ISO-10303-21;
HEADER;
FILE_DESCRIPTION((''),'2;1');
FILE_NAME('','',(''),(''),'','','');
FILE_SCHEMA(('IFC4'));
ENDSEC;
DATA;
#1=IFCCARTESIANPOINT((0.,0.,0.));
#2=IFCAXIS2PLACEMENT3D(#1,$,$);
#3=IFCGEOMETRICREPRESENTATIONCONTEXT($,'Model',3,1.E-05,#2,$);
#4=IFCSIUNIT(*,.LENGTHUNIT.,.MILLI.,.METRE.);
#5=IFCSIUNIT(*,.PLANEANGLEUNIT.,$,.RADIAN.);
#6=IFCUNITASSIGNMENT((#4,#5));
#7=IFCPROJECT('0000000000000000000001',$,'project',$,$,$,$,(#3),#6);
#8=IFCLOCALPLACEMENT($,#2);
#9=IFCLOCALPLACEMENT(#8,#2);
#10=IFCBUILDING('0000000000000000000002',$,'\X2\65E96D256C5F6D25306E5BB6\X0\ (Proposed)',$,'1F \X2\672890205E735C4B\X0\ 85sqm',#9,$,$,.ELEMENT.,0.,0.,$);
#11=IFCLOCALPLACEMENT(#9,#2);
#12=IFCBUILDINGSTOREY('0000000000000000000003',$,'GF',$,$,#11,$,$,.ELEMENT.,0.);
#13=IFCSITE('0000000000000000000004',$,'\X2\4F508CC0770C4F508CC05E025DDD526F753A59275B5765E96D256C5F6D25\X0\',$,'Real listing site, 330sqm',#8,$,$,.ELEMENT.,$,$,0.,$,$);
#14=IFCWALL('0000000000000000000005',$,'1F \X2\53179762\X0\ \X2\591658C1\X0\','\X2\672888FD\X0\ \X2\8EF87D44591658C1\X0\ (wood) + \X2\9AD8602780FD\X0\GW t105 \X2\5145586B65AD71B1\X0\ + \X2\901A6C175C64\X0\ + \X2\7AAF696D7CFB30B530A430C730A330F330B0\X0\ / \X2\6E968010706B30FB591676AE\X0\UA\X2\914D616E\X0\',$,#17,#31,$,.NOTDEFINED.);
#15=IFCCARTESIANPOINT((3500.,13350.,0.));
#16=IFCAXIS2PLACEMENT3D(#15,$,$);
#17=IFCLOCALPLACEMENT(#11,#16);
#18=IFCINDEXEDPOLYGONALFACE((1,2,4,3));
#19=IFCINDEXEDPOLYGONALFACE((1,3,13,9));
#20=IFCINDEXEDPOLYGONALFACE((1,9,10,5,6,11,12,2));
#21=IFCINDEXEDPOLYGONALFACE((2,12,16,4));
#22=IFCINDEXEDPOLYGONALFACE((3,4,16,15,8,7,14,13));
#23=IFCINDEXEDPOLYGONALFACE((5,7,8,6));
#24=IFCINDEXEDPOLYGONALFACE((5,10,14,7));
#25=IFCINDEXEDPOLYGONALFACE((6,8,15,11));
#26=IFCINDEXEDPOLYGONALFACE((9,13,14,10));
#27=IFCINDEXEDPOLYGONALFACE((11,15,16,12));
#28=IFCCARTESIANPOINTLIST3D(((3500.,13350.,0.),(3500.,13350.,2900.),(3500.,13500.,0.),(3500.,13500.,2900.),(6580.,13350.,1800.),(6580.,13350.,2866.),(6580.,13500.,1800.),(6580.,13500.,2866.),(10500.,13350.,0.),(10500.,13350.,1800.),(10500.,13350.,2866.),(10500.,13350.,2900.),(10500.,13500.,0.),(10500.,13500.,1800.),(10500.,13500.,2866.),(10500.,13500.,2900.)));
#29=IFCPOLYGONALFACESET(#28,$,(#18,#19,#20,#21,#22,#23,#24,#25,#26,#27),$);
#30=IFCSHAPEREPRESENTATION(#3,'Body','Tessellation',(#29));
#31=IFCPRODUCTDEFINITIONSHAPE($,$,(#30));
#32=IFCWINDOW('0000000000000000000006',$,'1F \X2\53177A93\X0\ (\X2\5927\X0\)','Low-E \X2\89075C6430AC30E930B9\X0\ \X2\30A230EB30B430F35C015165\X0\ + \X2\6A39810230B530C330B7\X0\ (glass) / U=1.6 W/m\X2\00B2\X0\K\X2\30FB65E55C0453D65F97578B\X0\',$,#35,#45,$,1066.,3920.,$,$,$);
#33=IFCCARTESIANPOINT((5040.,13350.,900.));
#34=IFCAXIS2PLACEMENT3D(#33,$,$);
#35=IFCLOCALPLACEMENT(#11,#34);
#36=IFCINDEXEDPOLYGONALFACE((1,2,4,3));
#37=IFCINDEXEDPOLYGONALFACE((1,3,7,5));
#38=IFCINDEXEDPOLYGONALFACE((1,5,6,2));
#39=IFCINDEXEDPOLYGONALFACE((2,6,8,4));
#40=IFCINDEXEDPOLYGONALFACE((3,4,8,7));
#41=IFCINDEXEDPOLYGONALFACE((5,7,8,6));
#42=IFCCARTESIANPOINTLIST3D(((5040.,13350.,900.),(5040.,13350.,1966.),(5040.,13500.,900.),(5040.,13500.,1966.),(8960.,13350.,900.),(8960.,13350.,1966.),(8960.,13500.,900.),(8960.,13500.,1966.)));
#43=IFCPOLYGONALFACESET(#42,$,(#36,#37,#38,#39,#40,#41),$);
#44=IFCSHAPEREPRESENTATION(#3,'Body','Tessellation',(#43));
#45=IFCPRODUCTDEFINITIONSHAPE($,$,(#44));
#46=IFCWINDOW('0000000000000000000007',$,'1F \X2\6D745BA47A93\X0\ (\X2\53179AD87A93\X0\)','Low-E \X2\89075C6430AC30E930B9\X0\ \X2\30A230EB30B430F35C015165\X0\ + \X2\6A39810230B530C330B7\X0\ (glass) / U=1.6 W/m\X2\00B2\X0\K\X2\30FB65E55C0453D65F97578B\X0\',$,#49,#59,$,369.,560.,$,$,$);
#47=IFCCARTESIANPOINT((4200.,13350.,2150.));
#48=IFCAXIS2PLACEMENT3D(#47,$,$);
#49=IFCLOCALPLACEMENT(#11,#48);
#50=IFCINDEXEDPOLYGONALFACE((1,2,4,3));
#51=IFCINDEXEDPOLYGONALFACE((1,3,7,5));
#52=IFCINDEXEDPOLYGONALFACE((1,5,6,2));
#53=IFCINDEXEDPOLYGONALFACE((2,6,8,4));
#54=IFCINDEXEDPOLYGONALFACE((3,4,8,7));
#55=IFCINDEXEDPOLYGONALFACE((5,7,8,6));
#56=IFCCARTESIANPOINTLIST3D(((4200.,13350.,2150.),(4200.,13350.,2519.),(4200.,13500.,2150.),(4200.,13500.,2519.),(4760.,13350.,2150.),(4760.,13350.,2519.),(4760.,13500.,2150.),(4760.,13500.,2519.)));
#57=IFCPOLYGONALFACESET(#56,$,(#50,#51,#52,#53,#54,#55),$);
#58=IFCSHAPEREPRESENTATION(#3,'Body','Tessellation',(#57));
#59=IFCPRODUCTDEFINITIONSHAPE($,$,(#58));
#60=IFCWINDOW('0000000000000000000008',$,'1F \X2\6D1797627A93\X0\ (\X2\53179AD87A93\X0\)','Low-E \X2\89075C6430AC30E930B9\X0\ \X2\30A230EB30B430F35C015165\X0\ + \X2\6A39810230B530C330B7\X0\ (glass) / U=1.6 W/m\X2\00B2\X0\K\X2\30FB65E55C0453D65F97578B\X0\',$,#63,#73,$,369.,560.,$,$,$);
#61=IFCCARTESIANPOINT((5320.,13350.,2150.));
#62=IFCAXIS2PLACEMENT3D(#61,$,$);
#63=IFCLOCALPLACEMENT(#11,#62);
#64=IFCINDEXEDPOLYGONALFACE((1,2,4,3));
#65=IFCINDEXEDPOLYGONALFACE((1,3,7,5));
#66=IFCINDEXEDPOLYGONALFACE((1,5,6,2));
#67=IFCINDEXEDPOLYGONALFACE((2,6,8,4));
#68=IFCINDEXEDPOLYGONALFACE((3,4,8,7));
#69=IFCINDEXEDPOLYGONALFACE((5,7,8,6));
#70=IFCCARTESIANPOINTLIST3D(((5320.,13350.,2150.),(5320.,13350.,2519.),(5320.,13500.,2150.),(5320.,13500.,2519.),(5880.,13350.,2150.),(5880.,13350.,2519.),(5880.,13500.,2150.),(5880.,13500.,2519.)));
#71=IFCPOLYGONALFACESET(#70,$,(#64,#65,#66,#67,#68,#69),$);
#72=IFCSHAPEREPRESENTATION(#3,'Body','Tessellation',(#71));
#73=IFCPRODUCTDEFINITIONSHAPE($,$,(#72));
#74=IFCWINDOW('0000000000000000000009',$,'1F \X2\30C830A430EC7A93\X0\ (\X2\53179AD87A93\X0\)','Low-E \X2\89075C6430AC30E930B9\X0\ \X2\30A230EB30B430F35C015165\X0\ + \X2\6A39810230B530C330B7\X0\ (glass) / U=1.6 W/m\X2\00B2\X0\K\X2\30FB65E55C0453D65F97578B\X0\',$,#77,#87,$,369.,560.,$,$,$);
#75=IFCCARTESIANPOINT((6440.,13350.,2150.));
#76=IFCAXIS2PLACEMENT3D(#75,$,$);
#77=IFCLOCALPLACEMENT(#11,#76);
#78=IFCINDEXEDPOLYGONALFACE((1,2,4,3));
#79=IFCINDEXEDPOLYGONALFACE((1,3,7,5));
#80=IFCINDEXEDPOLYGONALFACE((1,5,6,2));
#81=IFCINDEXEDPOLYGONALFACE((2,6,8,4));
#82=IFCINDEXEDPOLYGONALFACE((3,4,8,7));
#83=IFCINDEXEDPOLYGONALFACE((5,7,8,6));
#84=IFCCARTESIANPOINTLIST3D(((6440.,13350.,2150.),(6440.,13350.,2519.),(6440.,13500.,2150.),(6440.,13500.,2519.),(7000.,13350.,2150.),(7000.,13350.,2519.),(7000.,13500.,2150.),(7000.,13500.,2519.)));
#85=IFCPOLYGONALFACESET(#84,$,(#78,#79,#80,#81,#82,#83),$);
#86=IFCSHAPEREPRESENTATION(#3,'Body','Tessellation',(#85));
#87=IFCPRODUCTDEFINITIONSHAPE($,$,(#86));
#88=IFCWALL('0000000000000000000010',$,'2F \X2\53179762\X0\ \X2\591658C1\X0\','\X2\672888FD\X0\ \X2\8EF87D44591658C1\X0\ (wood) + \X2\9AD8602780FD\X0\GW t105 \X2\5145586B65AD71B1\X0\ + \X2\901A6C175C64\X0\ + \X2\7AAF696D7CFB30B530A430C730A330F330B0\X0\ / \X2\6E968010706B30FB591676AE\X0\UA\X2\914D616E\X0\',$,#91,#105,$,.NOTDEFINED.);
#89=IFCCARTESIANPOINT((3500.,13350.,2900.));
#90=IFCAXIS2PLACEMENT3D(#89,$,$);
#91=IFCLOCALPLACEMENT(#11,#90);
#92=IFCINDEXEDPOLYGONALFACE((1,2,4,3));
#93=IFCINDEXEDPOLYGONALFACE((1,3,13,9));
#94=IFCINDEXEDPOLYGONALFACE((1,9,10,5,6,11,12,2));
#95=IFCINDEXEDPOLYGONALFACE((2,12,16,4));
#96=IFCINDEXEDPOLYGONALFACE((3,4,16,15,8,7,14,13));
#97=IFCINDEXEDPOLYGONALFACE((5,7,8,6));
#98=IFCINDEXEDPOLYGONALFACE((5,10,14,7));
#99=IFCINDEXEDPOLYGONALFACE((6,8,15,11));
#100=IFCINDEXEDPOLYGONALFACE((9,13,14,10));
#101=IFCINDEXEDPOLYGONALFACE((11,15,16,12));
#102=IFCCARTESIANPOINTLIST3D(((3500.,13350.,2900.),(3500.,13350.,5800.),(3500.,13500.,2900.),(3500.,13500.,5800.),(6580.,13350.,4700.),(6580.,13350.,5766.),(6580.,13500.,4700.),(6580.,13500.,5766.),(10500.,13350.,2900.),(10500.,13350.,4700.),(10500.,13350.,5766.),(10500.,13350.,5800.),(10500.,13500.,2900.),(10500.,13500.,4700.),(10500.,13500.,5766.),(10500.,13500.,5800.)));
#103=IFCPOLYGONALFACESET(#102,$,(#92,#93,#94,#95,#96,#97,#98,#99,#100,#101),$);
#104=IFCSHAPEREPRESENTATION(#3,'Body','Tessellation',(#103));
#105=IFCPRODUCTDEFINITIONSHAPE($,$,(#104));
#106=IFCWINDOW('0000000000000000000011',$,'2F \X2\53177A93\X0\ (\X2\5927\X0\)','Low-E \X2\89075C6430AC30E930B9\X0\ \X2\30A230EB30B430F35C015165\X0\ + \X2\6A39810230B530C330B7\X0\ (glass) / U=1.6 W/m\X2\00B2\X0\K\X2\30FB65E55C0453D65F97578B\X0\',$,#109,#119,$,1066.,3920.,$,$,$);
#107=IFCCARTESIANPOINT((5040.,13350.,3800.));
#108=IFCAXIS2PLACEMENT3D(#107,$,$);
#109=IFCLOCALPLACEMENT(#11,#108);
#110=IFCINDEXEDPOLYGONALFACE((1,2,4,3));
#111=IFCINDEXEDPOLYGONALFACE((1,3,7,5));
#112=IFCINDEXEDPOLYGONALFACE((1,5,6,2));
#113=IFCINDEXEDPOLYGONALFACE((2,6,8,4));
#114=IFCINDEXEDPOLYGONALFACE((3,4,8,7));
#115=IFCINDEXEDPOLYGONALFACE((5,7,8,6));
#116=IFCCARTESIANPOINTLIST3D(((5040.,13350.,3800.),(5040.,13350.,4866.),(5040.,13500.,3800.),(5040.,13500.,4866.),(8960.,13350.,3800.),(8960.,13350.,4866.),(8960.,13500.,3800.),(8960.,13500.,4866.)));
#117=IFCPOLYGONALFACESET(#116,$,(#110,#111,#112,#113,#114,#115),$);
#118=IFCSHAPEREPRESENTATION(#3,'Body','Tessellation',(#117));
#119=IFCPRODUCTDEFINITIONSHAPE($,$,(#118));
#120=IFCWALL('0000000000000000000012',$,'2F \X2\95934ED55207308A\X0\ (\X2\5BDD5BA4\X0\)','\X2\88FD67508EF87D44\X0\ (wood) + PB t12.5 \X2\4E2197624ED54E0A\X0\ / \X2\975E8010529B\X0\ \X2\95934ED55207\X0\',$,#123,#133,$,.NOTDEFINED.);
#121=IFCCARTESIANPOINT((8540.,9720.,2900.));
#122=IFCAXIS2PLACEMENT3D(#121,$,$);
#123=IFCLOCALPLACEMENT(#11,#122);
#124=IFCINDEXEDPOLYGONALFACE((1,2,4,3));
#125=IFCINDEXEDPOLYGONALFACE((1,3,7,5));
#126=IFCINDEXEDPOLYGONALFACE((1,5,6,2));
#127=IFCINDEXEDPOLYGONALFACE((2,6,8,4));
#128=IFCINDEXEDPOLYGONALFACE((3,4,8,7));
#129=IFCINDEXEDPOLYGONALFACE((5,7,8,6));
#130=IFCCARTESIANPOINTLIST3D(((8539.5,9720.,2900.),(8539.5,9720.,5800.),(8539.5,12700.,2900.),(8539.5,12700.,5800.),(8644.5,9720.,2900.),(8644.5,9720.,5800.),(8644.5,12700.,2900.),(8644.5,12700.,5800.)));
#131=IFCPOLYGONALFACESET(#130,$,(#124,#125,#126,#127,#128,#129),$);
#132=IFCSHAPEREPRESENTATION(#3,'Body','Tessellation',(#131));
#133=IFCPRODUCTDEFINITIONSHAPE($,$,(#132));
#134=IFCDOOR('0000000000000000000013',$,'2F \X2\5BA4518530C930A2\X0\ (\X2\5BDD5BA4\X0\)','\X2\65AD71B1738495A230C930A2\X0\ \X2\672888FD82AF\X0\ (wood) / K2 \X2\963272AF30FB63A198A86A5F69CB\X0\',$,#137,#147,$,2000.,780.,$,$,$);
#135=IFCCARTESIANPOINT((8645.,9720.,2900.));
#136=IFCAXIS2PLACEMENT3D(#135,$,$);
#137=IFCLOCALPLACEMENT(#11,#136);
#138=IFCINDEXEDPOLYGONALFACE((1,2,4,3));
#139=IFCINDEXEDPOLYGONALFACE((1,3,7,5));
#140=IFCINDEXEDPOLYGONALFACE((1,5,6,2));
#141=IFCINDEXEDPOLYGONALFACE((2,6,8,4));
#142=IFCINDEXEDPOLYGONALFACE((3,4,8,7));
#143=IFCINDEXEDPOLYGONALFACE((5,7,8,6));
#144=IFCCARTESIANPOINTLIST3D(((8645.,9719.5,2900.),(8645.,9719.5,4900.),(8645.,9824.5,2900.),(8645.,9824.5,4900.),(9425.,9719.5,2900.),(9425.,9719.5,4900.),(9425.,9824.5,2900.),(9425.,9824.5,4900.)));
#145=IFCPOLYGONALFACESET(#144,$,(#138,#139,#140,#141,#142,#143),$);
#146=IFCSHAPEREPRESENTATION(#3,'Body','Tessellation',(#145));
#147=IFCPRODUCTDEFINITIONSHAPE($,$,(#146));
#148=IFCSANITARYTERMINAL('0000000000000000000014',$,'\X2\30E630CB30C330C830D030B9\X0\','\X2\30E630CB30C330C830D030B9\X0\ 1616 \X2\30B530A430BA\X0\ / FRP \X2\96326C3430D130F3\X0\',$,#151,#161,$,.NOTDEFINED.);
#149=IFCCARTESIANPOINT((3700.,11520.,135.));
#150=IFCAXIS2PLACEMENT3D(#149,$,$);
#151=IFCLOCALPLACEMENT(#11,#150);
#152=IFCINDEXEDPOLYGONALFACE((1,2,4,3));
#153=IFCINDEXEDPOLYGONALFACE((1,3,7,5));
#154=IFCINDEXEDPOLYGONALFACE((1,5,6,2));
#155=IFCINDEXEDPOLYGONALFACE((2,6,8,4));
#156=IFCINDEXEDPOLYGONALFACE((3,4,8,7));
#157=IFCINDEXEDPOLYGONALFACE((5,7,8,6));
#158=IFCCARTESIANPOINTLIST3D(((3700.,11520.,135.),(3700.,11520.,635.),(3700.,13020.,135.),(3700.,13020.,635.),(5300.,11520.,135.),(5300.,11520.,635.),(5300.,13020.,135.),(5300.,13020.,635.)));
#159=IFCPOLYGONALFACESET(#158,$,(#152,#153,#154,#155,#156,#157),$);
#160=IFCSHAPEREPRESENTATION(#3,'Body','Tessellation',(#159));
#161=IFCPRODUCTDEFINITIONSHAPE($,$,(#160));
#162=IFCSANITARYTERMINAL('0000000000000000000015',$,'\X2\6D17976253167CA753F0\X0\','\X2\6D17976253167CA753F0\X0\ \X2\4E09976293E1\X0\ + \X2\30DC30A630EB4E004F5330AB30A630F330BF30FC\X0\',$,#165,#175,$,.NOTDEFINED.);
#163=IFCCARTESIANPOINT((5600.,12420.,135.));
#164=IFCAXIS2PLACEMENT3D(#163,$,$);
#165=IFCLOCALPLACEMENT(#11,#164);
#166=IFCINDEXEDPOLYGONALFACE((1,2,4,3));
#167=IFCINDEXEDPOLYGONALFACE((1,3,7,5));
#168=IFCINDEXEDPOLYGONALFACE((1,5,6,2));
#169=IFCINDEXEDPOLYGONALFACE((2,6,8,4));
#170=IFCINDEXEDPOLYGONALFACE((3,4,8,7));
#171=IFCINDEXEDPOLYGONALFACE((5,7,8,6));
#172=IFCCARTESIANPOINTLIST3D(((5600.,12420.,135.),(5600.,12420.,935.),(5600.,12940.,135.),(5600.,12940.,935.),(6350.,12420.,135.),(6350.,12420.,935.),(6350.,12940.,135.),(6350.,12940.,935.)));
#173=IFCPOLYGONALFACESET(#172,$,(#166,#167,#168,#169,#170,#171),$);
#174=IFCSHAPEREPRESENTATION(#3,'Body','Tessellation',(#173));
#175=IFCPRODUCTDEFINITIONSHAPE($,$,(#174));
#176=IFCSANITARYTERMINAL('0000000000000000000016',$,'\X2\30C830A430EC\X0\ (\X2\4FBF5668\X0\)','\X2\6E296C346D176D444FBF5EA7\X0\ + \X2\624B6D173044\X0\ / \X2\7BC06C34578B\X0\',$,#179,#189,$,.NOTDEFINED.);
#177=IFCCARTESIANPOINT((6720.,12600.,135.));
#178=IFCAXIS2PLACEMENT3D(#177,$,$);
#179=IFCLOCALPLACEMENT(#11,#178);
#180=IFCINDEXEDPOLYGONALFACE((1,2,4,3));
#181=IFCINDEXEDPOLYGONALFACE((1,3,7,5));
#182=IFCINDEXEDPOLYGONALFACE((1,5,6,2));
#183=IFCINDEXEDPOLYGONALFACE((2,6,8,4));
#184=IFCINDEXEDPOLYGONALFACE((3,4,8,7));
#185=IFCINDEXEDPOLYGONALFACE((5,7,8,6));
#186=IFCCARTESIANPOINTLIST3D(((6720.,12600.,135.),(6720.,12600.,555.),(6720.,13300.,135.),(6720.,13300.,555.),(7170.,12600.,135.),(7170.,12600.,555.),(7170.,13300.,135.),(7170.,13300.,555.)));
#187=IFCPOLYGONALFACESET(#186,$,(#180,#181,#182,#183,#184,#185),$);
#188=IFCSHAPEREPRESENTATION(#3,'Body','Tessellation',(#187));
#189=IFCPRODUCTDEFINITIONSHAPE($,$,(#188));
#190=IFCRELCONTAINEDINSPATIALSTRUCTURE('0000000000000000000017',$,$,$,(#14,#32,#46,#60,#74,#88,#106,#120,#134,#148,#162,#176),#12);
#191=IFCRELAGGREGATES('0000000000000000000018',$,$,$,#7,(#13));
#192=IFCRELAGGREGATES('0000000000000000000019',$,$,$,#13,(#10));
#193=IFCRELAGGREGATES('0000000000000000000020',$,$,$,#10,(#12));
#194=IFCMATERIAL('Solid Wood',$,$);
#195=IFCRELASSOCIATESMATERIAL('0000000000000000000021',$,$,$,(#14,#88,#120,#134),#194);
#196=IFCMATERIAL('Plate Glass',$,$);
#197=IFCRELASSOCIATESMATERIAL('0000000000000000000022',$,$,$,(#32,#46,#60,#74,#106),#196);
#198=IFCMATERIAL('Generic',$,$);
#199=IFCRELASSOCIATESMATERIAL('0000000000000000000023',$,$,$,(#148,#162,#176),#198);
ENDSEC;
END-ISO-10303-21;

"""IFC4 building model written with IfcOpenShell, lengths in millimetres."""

from ifc_helpers import new_model, si_unit, frame, frame_2d, origin, place, context, project, spatial, rectangle, extrude, material, element, fill, save


model = new_model("IFC4")

# Units and contexts
model_context = context("Model", 3, precision=1e-05, world=origin())
ifc_project = project(units=[si_unit("LENGTHUNIT", "METRE", prefix="MILLI"), si_unit("PLANEANGLEUNIT", "RADIAN")], contexts=[model_context])

# Site, building, storey
site_placement = place(None, origin())
site = spatial("IfcSite", under=ifc_project, at=site_placement, Name="佐賀県佐賀市川副町大字早津江津", ObjectType="Real listing site, 330sqm", CompositionType="ELEMENT", RefElevation=0.0)
building_placement = place(site_placement, origin())
building = spatial("IfcBuilding", under=site, at=building_placement, Name="早津江津の家 (Proposed)", ObjectType="1F 木造平屋 85sqm", CompositionType="ELEMENT", ElevationOfRefHeight=0.0, ElevationOfTerrain=0.0)
storey_placement = place(building_placement, origin())
storey = spatial("IfcBuildingStorey", under=building, at=storey_placement, Name="GF", CompositionType="ELEMENT", Elevation=0.0)

# Wall, openings, windows
ifc_material_1 = material(Name="Solid Wood")
wall_1_placement = place(storey_placement, frame((3500.0, 13350.0, 0.0)))
wall_1 = element("IfcWall", 1, at=wall_1_placement, inside=storey, material=ifc_material_1, Name="1F 北面 外壁", Description="木製 軸組外壁 (wood) + 高性能GW t105 充填断熱 + 通気層 + 窯業系サイディング / 準耐火・外皮UA配慮", PredefinedType="NOTDEFINED", context=model_context, shape_type="SweptSolid", body=[
    extrude(rectangle(XDim=7000.0, YDim=150.0, at=frame_2d((3500.0, 75.0))), frame((3500.0, 13350.0, 0.0)), (0.0, 0.0, 1.0), 2900.0),
])
opening_1_placement = place(storey_placement, frame((5040.0, 13350.0, 900.0)))
opening_1 = element("IfcOpeningElement", 2, at=opening_1_placement, cuts=wall_1, PredefinedType="NOTDEFINED", context=model_context, shape_type="SweptSolid", body=[
    extrude(rectangle(XDim=3920.0, YDim=150.0, at=frame_2d((1960.0, 75.0))), frame((5040.0, 13350.0, 900.0)), (0.0, 0.0, 1.0), 1066.0),
])
opening_2_placement = place(storey_placement, frame((4200.0, 13350.0, 2150.0)))
opening_2 = element("IfcOpeningElement", 3, at=opening_2_placement, cuts=wall_1, PredefinedType="NOTDEFINED", context=model_context, shape_type="SweptSolid", body=[
    extrude(rectangle(XDim=560.0, YDim=150.0, at=frame_2d((280.0, 75.0))), frame((4200.0, 13350.0, 2150.0)), (0.0, 0.0, 1.0), 369.0),
])
opening_3_placement = place(storey_placement, frame((5320.0, 13350.0, 2150.0)))
opening_3 = element("IfcOpeningElement", 4, at=opening_3_placement, cuts=wall_1, PredefinedType="NOTDEFINED", context=model_context, shape_type="SweptSolid", body=[
    extrude(rectangle(XDim=560.0, YDim=150.0, at=frame_2d((280.0, 75.0))), frame((5320.0, 13350.0, 2150.0)), (0.0, 0.0, 1.0), 369.0),
])
opening_4_placement = place(storey_placement, frame((6440.0, 13350.0, 2150.0)))
opening_4 = element("IfcOpeningElement", 5, at=opening_4_placement, cuts=wall_1, PredefinedType="NOTDEFINED", context=model_context, shape_type="SweptSolid", body=[
    extrude(rectangle(XDim=560.0, YDim=150.0, at=frame_2d((280.0, 75.0))), frame((6440.0, 13350.0, 2150.0)), (0.0, 0.0, 1.0), 369.0),
])
ifc_material_2 = material(Name="Plate Glass")
window_1_placement = place(storey_placement, frame((5040.0, 13350.0, 900.0)))
window_1 = element("IfcWindow", 6, at=window_1_placement, inside=storey, material=ifc_material_2, Name="1F 北窓 (大)", Description="Low-E 複層ガラス アルゴン封入 + 樹脂サッシ (glass) / U=1.6 W/m²K・日射取得型", OverallHeight=1066.0, OverallWidth=3920.0, context=model_context, shape_type="SweptSolid", body=[
    extrude(rectangle(XDim=3920.0, YDim=150.0, at=frame_2d((1960.0, 75.0))), frame((5040.0, 13350.0, 900.0)), (0.0, 0.0, 1.0), 1066.0),
])
fill(opening_1, window_1)
window_2_placement = place(storey_placement, frame((4200.0, 13350.0, 2150.0)))
window_2 = element("IfcWindow", 7, at=window_2_placement, inside=storey, material=ifc_material_2, Name="1F 浴室窓 (北高窓)", Description="Low-E 複層ガラス アルゴン封入 + 樹脂サッシ (glass) / U=1.6 W/m²K・日射取得型", OverallHeight=369.0, OverallWidth=560.0, context=model_context, shape_type="SweptSolid", body=[
    extrude(rectangle(XDim=560.0, YDim=150.0, at=frame_2d((280.0, 75.0))), frame((4200.0, 13350.0, 2150.0)), (0.0, 0.0, 1.0), 369.0),
])
fill(opening_2, window_2)
window_3_placement = place(storey_placement, frame((5320.0, 13350.0, 2150.0)))
window_3 = element("IfcWindow", 8, at=window_3_placement, inside=storey, material=ifc_material_2, Name="1F 洗面窓 (北高窓)", Description="Low-E 複層ガラス アルゴン封入 + 樹脂サッシ (glass) / U=1.6 W/m²K・日射取得型", OverallHeight=369.0, OverallWidth=560.0, context=model_context, shape_type="SweptSolid", body=[
    extrude(rectangle(XDim=560.0, YDim=150.0, at=frame_2d((280.0, 75.0))), frame((5320.0, 13350.0, 2150.0)), (0.0, 0.0, 1.0), 369.0),
])
fill(opening_3, window_3)
window_4_placement = place(storey_placement, frame((6440.0, 13350.0, 2150.0)))
window_4 = element("IfcWindow", 9, at=window_4_placement, inside=storey, material=ifc_material_2, Name="1F トイレ窓 (北高窓)", Description="Low-E 複層ガラス アルゴン封入 + 樹脂サッシ (glass) / U=1.6 W/m²K・日射取得型", OverallHeight=369.0, OverallWidth=560.0, context=model_context, shape_type="SweptSolid", body=[
    extrude(rectangle(XDim=560.0, YDim=150.0, at=frame_2d((280.0, 75.0))), frame((6440.0, 13350.0, 2150.0)), (0.0, 0.0, 1.0), 369.0),
])
fill(opening_4, window_4)

# Wall, opening, window
wall_2_placement = place(storey_placement, frame((3500.0, 13350.0, 2900.0)))
wall_2 = element("IfcWall", 10, at=wall_2_placement, inside=storey, material=ifc_material_1, Name="2F 北面 外壁", Description="木製 軸組外壁 (wood) + 高性能GW t105 充填断熱 + 通気層 + 窯業系サイディング / 準耐火・外皮UA配慮", PredefinedType="NOTDEFINED", context=model_context, shape_type="SweptSolid", body=[
    extrude(rectangle(XDim=7000.0, YDim=150.0, at=frame_2d((3500.0, 75.0))), frame((3500.0, 13350.0, 2900.0)), (0.0, 0.0, 1.0), 2900.0),
])
opening_5_placement = place(storey_placement, frame((5040.0, 13350.0, 3800.0)))
opening_5 = element("IfcOpeningElement", 11, at=opening_5_placement, cuts=wall_2, PredefinedType="NOTDEFINED", context=model_context, shape_type="SweptSolid", body=[
    extrude(rectangle(XDim=3920.0, YDim=150.0, at=frame_2d((1960.0, 75.0))), frame((5040.0, 13350.0, 3800.0)), (0.0, 0.0, 1.0), 1066.0),
])
window_5_placement = place(storey_placement, frame((5040.0, 13350.0, 3800.0)))
window_5 = element("IfcWindow", 12, at=window_5_placement, inside=storey, material=ifc_material_2, Name="2F 北窓 (大)", Description="Low-E 複層ガラス アルゴン封入 + 樹脂サッシ (glass) / U=1.6 W/m²K・日射取得型", OverallHeight=1066.0, OverallWidth=3920.0, context=model_context, shape_type="SweptSolid", body=[
    extrude(rectangle(XDim=3920.0, YDim=150.0, at=frame_2d((1960.0, 75.0))), frame((5040.0, 13350.0, 3800.0)), (0.0, 0.0, 1.0), 1066.0),
])
fill(opening_5, window_5)

# Wall
wall_3_placement = place(storey_placement, frame((8540.0, 9720.0, 2900.0)))
element("IfcWall", 13, at=wall_3_placement, inside=storey, material=ifc_material_1, Name="2F 間仕切り (寝室)", Description="製材軸組 (wood) + PB t12.5 両面仕上 / 非耐力 間仕切", PredefinedType="NOTDEFINED", context=model_context, shape_type="SweptSolid", body=[
    extrude(rectangle(XDim=105.0, YDim=2980.0, at=frame_2d((52.0, 1490.0))), frame((8540.0, 9720.0, 2900.0)), (0.0, 0.0, 1.0), 2900.0),
])

# Door
door_1_placement = place(storey_placement, frame((8645.0, 9720.0, 2900.0)))
element("IfcDoor", 14, at=door_1_placement, inside=storey, material=ifc_material_1, Name="2F 室内ドア (寝室)", Description="断熱玄関ドア 木製芯 (wood) / K2 防犯・採風機構", OverallHeight=2000.0, OverallWidth=780.0, context=model_context, shape_type="SweptSolid", body=[
    extrude(rectangle(XDim=780.0, YDim=105.0, at=frame_2d((390.0, 52.0))), frame((8645.0, 9720.0, 2900.0)), (0.0, 0.0, 1.0), 2000.0),
])

# Sanitary terminals
ifc_material_3 = material(Name="Generic")
sanitary_terminal_1_placement = place(storey_placement, frame((3700.0, 11520.0, 135.0)))
element("IfcSanitaryTerminal", 15, at=sanitary_terminal_1_placement, inside=storey, material=ifc_material_3, Name="ユニットバス", Description="ユニットバス 1616 サイズ / FRP 防水パン", PredefinedType="NOTDEFINED", context=model_context, shape_type="SweptSolid", body=[
    extrude(rectangle(XDim=1600.0, YDim=1500.0, at=frame_2d((800.0, 750.0))), frame((3700.0, 11520.0, 135.0)), (0.0, 0.0, 1.0), 500.0),
])
sanitary_terminal_2_placement = place(storey_placement, frame((5600.0, 12420.0, 135.0)))
element("IfcSanitaryTerminal", 16, at=sanitary_terminal_2_placement, inside=storey, material=ifc_material_3, Name="洗面化粧台", Description="洗面化粧台 三面鏡 + ボウル一体カウンター", PredefinedType="NOTDEFINED", context=model_context, shape_type="SweptSolid", body=[
    extrude(rectangle(XDim=750.0, YDim=520.0, at=frame_2d((375.0, 260.0))), frame((5600.0, 12420.0, 135.0)), (0.0, 0.0, 1.0), 800.0),
])
sanitary_terminal_3_placement = place(storey_placement, frame((6720.0, 12600.0, 135.0)))
element("IfcSanitaryTerminal", 17, at=sanitary_terminal_3_placement, inside=storey, material=ifc_material_3, Name="トイレ (便器)", Description="温水洗浄便座 + 手洗い / 節水型", PredefinedType="NOTDEFINED", context=model_context, shape_type="SweptSolid", body=[
    extrude(rectangle(XDim=450.0, YDim=700.0, at=frame_2d((225.0, 350.0))), frame((6720.0, 12600.0, 135.0)), (0.0, 0.0, 1.0), 420.0),
])

save(model, "model.ifc")
